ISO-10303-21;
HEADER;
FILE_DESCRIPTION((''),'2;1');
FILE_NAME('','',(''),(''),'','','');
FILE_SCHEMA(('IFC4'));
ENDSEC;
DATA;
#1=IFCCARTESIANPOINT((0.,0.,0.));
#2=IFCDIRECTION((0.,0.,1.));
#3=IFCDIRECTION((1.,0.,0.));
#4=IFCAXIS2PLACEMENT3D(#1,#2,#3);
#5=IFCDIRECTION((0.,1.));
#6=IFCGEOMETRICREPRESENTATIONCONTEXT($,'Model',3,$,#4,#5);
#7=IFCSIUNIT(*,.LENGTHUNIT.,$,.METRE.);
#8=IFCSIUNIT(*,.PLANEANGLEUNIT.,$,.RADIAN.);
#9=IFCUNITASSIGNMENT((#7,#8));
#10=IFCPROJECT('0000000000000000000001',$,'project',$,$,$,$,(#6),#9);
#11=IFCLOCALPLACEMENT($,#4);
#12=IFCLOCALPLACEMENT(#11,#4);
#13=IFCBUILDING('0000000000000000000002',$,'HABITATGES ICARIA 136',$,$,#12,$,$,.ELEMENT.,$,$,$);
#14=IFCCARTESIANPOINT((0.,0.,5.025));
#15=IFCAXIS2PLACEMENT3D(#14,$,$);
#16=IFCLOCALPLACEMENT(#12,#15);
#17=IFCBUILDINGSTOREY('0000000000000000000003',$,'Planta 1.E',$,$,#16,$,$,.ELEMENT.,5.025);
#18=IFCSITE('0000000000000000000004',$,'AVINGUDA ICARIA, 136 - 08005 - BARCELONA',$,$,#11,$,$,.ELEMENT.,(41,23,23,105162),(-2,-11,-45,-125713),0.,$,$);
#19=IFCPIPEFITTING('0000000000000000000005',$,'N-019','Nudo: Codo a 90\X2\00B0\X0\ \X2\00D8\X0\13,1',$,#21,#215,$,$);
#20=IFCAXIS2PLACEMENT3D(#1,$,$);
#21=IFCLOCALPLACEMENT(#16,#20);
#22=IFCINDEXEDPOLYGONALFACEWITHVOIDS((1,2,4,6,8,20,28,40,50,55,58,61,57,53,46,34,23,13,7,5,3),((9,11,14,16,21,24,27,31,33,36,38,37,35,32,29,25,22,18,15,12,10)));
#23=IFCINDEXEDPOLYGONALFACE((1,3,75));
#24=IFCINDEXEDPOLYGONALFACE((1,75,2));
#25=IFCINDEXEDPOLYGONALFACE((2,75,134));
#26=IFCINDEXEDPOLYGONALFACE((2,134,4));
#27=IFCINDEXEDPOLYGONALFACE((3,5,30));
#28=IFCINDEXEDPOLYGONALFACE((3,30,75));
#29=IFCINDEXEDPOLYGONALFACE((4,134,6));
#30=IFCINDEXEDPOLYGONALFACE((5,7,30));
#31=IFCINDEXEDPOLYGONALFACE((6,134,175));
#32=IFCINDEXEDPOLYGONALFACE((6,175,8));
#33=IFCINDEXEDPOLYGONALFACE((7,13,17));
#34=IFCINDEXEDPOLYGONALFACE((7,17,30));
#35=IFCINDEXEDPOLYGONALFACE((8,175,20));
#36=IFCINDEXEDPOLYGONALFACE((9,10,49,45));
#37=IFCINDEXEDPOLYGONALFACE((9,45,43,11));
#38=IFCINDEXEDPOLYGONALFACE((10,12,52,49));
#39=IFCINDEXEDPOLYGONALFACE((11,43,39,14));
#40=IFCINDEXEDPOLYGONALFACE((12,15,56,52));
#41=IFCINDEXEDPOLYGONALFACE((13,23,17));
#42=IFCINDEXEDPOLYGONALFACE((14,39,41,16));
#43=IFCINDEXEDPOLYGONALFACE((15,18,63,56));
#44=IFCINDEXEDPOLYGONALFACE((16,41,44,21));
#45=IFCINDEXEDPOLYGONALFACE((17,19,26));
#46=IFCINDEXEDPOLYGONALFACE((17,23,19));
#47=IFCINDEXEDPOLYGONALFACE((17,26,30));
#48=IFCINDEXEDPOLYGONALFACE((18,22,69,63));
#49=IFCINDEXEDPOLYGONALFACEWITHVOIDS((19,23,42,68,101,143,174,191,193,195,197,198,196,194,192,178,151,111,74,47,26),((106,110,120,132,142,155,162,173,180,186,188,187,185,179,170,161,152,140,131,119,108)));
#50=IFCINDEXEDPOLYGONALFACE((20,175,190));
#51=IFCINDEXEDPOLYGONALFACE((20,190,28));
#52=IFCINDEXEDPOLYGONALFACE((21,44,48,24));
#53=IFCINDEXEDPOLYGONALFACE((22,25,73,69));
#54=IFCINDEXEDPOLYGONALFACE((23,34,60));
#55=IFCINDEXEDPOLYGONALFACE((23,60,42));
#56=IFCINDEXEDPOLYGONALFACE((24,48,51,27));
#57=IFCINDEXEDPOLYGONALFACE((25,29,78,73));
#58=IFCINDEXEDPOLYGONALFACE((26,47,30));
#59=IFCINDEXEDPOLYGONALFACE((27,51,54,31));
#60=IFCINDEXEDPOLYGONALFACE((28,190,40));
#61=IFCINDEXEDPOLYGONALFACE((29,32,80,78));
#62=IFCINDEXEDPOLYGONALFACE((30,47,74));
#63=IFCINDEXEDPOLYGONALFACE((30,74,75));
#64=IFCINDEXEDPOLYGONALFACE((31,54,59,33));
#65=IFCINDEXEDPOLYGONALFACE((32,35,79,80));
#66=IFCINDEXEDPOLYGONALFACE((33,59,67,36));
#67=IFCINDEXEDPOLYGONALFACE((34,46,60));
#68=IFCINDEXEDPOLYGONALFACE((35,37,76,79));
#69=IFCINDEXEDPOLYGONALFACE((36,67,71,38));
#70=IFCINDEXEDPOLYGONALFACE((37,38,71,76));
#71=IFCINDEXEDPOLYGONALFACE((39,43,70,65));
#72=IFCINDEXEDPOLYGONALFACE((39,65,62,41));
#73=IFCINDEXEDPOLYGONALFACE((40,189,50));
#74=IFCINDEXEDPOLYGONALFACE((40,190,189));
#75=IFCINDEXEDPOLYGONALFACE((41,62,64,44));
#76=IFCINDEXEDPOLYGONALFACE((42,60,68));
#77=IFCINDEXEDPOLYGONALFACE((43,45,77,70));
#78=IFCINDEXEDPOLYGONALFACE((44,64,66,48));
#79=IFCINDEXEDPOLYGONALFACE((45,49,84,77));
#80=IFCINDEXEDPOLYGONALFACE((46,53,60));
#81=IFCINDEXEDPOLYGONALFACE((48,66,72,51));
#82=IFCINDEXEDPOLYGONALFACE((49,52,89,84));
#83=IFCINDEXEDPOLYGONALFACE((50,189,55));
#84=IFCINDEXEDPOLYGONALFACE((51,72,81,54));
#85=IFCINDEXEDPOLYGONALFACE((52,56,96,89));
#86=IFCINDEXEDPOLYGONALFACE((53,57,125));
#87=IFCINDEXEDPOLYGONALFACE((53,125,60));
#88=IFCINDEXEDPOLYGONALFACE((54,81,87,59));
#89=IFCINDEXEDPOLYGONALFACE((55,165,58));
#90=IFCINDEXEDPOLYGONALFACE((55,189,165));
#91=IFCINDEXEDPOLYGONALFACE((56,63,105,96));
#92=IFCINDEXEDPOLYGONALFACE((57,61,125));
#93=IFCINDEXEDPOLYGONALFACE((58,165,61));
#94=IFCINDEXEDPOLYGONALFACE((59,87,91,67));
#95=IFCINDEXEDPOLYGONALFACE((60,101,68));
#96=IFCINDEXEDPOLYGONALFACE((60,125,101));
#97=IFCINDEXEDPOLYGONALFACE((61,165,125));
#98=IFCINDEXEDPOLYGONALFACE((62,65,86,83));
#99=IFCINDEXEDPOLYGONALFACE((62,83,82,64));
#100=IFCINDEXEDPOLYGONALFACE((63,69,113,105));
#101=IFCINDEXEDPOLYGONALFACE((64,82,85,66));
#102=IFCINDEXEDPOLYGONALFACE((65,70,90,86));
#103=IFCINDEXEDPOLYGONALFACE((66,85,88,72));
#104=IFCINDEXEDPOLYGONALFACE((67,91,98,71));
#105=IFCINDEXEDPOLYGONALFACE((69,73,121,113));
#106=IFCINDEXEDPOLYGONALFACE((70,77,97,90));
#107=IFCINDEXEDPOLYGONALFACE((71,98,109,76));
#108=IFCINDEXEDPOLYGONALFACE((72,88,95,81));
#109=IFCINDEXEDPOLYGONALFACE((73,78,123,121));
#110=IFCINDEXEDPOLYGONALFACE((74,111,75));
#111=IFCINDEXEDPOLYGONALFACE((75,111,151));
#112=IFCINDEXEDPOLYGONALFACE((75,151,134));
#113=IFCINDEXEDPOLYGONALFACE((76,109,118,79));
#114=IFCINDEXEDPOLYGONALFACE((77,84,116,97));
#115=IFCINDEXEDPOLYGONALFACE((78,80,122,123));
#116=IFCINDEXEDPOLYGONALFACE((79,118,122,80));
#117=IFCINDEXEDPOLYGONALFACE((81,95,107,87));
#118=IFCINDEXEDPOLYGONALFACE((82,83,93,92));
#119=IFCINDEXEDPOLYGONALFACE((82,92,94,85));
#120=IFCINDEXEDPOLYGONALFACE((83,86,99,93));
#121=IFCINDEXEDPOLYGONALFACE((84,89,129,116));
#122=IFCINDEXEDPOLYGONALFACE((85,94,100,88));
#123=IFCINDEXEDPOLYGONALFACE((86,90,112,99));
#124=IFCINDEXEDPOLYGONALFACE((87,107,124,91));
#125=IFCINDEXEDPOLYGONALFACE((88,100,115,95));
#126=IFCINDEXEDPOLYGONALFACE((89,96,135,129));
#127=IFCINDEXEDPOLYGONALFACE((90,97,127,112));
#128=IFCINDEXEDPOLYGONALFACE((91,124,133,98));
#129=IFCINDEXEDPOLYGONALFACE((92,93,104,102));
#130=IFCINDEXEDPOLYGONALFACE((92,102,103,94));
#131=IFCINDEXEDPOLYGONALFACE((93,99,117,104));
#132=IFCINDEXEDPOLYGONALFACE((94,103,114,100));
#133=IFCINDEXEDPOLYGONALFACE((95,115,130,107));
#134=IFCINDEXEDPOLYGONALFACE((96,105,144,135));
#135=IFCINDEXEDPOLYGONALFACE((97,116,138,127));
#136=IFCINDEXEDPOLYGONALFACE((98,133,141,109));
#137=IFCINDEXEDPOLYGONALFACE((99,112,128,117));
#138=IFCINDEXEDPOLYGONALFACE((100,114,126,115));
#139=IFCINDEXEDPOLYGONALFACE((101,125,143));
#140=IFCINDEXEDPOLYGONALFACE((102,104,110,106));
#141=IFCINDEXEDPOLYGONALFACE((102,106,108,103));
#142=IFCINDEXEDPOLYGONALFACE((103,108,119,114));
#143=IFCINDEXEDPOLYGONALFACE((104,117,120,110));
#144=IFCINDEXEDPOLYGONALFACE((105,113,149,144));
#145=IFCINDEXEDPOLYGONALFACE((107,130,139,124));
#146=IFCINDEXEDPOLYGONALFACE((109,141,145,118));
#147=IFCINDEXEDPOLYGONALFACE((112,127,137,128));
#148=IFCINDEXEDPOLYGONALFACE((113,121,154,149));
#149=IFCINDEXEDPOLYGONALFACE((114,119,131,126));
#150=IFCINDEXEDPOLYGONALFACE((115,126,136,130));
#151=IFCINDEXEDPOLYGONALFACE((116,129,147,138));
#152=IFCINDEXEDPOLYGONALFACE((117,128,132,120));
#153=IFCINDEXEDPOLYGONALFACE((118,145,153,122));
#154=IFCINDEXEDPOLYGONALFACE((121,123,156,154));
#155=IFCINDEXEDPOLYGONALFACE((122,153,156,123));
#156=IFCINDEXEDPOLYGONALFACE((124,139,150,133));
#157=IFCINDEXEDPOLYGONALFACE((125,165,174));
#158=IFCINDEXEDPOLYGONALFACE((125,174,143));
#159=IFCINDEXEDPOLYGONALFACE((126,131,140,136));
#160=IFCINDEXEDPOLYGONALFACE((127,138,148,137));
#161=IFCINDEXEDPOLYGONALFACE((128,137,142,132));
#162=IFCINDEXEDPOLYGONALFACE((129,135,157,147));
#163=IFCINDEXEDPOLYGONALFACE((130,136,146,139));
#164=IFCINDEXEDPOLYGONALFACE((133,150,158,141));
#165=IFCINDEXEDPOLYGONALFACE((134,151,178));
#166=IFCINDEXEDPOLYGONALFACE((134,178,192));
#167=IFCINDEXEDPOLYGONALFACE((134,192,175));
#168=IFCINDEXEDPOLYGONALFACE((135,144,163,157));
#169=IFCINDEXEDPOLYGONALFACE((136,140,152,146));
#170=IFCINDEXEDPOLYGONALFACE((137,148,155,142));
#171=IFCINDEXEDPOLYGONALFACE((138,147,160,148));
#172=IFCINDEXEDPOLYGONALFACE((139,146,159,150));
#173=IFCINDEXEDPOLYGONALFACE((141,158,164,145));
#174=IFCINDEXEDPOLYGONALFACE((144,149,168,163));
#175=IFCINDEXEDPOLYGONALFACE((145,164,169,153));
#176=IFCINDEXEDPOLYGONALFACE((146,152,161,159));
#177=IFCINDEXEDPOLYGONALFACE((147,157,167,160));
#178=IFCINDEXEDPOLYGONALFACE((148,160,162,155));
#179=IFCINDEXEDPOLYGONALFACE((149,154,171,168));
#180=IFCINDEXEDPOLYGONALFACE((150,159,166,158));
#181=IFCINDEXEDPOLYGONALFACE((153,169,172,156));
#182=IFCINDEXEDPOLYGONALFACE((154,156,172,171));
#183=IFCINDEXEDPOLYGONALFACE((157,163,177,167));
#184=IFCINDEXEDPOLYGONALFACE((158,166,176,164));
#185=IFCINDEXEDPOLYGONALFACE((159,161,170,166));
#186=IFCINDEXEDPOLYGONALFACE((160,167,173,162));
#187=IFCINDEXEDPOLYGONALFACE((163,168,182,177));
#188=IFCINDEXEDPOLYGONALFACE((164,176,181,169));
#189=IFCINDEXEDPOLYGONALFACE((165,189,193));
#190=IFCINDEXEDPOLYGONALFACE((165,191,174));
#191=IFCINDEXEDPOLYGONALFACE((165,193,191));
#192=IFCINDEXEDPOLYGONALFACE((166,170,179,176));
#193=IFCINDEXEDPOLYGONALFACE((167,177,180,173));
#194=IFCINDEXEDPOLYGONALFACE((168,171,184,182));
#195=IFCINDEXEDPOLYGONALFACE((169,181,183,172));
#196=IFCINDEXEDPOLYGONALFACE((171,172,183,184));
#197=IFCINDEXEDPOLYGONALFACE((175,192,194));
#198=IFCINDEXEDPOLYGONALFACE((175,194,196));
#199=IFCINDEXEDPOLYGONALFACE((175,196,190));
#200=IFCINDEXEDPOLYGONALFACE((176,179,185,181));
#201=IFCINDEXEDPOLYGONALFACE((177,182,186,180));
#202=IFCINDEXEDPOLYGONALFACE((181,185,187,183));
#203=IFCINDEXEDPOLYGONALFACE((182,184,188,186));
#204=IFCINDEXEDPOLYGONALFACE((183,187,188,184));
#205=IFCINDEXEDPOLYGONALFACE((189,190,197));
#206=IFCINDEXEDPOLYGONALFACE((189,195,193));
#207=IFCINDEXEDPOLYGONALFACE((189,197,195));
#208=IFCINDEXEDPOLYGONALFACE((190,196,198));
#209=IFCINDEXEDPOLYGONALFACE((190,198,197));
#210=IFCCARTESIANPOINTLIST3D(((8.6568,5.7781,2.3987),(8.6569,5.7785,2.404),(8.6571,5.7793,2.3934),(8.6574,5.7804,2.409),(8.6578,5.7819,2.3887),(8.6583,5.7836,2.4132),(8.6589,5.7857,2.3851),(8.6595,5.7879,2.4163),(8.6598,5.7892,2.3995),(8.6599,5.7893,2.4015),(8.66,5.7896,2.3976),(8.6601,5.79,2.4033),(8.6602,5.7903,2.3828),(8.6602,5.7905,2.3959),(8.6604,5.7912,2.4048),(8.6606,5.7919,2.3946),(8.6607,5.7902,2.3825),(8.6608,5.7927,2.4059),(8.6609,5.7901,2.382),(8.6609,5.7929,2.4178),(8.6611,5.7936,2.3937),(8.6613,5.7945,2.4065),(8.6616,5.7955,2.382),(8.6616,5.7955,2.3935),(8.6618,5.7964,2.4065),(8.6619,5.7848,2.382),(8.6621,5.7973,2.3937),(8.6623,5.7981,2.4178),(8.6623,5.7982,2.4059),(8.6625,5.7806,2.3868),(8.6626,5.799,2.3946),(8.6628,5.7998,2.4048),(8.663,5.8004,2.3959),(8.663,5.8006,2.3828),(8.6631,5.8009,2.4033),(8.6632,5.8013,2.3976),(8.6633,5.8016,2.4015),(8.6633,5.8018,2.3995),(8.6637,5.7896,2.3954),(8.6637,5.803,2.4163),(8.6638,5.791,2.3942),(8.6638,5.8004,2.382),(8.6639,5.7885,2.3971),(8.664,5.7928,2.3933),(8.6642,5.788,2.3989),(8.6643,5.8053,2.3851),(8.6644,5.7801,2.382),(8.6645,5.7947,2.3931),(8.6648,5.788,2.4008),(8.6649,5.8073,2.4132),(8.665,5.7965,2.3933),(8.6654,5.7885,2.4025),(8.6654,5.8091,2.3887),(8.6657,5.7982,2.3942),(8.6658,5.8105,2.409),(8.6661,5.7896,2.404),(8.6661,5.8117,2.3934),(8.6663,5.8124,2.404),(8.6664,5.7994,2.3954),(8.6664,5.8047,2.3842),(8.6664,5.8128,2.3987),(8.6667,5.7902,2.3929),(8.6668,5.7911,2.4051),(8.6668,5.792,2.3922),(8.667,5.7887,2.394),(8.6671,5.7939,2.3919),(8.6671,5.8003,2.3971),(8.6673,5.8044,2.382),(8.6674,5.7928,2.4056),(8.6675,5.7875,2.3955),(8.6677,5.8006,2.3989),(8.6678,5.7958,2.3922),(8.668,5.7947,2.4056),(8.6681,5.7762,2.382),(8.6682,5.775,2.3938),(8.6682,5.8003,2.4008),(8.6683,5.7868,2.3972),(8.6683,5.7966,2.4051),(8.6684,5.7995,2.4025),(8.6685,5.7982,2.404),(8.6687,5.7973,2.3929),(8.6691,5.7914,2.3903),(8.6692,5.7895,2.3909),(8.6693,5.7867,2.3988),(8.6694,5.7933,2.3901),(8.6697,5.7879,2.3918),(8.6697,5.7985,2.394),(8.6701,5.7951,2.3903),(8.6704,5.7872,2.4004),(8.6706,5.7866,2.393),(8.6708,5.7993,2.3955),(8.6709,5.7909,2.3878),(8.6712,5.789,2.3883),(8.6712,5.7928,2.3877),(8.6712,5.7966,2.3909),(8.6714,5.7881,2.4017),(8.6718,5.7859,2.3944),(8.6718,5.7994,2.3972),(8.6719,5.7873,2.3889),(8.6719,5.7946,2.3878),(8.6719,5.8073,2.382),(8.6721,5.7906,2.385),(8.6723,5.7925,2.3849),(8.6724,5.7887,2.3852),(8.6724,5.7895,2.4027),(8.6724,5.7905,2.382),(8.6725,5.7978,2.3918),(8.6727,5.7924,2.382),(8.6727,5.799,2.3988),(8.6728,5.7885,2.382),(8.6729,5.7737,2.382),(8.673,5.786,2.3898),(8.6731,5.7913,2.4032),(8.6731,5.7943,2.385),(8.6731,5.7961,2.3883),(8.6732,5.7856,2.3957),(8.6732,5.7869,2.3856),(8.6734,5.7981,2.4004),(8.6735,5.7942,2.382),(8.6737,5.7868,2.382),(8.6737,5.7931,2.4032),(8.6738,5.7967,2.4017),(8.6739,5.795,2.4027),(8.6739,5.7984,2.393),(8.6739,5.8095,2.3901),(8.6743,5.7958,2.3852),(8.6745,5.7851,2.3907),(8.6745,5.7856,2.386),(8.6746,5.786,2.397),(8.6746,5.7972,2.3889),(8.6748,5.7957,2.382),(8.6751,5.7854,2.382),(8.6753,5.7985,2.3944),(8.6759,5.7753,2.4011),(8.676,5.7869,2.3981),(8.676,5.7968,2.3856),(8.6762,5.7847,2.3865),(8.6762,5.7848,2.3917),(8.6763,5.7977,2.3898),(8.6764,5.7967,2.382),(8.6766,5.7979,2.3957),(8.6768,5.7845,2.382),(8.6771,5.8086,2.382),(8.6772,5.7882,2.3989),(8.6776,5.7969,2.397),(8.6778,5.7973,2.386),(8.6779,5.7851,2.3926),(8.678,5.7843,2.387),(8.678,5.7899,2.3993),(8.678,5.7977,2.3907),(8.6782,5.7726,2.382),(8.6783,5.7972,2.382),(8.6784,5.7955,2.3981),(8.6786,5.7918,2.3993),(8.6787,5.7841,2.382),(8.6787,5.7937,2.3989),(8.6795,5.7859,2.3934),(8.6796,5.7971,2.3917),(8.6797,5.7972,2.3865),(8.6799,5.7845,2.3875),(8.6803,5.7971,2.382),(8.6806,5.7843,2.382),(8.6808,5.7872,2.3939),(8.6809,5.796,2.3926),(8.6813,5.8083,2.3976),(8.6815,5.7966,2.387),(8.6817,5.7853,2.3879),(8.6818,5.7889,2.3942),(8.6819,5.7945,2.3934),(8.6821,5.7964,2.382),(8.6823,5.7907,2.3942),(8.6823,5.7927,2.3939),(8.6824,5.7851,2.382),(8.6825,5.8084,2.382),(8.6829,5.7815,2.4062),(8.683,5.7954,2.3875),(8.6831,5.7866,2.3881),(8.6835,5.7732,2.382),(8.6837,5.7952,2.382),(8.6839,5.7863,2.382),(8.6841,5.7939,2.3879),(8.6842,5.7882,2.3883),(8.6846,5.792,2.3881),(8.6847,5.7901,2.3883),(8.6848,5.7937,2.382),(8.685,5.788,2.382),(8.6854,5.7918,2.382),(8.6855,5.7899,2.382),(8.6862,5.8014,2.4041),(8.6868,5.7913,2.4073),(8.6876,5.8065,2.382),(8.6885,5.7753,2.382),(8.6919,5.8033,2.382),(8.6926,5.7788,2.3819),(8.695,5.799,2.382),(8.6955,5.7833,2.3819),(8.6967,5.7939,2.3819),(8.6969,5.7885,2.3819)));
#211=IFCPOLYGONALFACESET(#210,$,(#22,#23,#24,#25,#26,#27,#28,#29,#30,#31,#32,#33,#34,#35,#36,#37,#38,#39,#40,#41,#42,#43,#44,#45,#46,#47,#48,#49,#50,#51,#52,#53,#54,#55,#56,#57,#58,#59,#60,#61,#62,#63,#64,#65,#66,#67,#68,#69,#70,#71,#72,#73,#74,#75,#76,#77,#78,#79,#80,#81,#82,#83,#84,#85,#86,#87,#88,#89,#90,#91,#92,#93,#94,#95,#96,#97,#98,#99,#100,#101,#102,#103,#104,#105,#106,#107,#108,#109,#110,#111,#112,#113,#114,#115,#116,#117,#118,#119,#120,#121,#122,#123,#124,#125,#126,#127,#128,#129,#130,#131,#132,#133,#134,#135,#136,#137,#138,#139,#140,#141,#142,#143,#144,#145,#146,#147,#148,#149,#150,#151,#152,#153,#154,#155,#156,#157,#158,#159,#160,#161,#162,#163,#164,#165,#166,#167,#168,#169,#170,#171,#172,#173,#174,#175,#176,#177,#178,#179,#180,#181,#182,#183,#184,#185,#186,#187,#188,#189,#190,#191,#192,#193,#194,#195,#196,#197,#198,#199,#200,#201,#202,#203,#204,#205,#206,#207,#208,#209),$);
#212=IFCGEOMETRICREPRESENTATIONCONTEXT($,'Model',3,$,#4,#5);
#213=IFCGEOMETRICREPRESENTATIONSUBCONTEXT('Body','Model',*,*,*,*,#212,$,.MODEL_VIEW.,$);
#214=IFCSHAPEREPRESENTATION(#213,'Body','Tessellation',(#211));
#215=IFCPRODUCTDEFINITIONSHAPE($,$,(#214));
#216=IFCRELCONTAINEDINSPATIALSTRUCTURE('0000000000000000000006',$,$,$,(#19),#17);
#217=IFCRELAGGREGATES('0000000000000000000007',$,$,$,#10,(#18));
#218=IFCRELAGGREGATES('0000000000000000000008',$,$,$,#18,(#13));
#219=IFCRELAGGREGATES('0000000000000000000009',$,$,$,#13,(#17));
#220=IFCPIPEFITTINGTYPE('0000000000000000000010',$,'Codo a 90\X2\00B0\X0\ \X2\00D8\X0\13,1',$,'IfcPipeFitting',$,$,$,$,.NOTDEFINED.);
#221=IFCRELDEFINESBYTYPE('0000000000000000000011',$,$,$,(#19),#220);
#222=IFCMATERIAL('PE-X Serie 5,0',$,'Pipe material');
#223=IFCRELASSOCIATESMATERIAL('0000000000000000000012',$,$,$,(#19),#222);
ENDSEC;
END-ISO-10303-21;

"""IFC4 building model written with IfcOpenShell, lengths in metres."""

from ifc_helpers import new_model, entity, si_unit, direction, frame, origin_with_axes, place, context, subcontext, project, spatial, source, transform, mapped, material, type_object, element, save


model = new_model("IFC4")

# Units and contexts
model_context_1 = context("Model", 3, world=origin_with_axes(), true_north=direction((0.0, 1.0)))
model_context_2 = context("Model", 3, world=origin_with_axes(), true_north=direction((0.0, 1.0)))
body_context_1 = subcontext(model_context_2, "Body", "Model", "MODEL_VIEW")
ifc_project = project(units=[si_unit("LENGTHUNIT", "METRE"), si_unit("PLANEANGLEUNIT", "RADIAN")], contexts=[model_context_1])

# Site, building, storey
site_placement = place(None, origin_with_axes())
site = spatial("IfcSite", under=ifc_project, at=site_placement, Name="AVINGUDA ICARIA, 136 - 08005 - BARCELONA", CompositionType="ELEMENT", RefLatitude=(41, 23, 23, 105162), RefLongitude=(-2, -11, -45, -125713), RefElevation=0.0)
building_placement = place(site_placement, origin_with_axes())
building = spatial("IfcBuilding", under=site, at=building_placement, Name="HABITATGES ICARIA 136", CompositionType="ELEMENT")
storey_placement = place(building_placement, frame((0.0, 0.0, 5.025)))
storey = spatial("IfcBuildingStorey", under=building, at=storey_placement, Name="Planta 1.E", CompositionType="ELEMENT", Elevation=5.025)

# Pipe fitting
ifc_material_1 = material(Name="PE-X Serie 5,0", Category="Pipe material")
placement_1 = place(None, origin_with_axes())
placement_2 = place(placement_1, origin_with_axes())
placement_3 = place(placement_2, frame((0.0, 0.0, 5.025)))
pipe_fitting_type_1 = type_object("IfcPipeFittingType", Name="Codo a 90° Ø13,1", ApplicableOccurrence="IfcPipeFitting", PredefinedType="NOTDEFINED")
shared_shape_1 = source(origin_with_axes(), body_context_1, "Body", "SweptSolid", [
    entity("IfcRevolvedAreaSolid", entity("IfcCircleHollowProfileDef", "AREA", None, entity("IfcAxis2Placement2D", entity("IfcCartesianPoint", [0.0, 0.0]), entity("IfcDirection", [1.0, 0.0])), 0.0181, 0.0115), entity("IfcAxis2Placement3D", entity("IfcCartesianPoint", [0.0181, 0.0, 0.0]), entity("IfcDirection", [-1.0, 0.0, 0.0]), entity("IfcDirection", [0.0, -1.0, 0.0])), entity("IfcAxis1Placement", entity("IfcCartesianPoint", [0.0181, 0.0, 0.0]), entity("IfcDirection", [0.0, 1.0, 0.0])), 1.570796),
])
pipe_fitting_1_placement = place(placement_3, origin_with_axes())
element("IfcPipeFitting", 1, at=pipe_fitting_1_placement, inside=storey, type_object=pipe_fitting_type_1, material=ifc_material_1, Name="N-019", Description="Nudo: Codo a 90° Ø13,1", context=body_context_1, shape_type="MappedRepresentation", body=[
    mapped(shared_shape_1, transform((8.679, 5.7907, 2.4), x_axis=(-0.96374, 0.266843, 0.0), y_axis=(0.0, 0.0, 1.0), z_axis=(0.266843, 0.96374, 0.0), scale=1.0)),
])

save(model, "model.ifc")
